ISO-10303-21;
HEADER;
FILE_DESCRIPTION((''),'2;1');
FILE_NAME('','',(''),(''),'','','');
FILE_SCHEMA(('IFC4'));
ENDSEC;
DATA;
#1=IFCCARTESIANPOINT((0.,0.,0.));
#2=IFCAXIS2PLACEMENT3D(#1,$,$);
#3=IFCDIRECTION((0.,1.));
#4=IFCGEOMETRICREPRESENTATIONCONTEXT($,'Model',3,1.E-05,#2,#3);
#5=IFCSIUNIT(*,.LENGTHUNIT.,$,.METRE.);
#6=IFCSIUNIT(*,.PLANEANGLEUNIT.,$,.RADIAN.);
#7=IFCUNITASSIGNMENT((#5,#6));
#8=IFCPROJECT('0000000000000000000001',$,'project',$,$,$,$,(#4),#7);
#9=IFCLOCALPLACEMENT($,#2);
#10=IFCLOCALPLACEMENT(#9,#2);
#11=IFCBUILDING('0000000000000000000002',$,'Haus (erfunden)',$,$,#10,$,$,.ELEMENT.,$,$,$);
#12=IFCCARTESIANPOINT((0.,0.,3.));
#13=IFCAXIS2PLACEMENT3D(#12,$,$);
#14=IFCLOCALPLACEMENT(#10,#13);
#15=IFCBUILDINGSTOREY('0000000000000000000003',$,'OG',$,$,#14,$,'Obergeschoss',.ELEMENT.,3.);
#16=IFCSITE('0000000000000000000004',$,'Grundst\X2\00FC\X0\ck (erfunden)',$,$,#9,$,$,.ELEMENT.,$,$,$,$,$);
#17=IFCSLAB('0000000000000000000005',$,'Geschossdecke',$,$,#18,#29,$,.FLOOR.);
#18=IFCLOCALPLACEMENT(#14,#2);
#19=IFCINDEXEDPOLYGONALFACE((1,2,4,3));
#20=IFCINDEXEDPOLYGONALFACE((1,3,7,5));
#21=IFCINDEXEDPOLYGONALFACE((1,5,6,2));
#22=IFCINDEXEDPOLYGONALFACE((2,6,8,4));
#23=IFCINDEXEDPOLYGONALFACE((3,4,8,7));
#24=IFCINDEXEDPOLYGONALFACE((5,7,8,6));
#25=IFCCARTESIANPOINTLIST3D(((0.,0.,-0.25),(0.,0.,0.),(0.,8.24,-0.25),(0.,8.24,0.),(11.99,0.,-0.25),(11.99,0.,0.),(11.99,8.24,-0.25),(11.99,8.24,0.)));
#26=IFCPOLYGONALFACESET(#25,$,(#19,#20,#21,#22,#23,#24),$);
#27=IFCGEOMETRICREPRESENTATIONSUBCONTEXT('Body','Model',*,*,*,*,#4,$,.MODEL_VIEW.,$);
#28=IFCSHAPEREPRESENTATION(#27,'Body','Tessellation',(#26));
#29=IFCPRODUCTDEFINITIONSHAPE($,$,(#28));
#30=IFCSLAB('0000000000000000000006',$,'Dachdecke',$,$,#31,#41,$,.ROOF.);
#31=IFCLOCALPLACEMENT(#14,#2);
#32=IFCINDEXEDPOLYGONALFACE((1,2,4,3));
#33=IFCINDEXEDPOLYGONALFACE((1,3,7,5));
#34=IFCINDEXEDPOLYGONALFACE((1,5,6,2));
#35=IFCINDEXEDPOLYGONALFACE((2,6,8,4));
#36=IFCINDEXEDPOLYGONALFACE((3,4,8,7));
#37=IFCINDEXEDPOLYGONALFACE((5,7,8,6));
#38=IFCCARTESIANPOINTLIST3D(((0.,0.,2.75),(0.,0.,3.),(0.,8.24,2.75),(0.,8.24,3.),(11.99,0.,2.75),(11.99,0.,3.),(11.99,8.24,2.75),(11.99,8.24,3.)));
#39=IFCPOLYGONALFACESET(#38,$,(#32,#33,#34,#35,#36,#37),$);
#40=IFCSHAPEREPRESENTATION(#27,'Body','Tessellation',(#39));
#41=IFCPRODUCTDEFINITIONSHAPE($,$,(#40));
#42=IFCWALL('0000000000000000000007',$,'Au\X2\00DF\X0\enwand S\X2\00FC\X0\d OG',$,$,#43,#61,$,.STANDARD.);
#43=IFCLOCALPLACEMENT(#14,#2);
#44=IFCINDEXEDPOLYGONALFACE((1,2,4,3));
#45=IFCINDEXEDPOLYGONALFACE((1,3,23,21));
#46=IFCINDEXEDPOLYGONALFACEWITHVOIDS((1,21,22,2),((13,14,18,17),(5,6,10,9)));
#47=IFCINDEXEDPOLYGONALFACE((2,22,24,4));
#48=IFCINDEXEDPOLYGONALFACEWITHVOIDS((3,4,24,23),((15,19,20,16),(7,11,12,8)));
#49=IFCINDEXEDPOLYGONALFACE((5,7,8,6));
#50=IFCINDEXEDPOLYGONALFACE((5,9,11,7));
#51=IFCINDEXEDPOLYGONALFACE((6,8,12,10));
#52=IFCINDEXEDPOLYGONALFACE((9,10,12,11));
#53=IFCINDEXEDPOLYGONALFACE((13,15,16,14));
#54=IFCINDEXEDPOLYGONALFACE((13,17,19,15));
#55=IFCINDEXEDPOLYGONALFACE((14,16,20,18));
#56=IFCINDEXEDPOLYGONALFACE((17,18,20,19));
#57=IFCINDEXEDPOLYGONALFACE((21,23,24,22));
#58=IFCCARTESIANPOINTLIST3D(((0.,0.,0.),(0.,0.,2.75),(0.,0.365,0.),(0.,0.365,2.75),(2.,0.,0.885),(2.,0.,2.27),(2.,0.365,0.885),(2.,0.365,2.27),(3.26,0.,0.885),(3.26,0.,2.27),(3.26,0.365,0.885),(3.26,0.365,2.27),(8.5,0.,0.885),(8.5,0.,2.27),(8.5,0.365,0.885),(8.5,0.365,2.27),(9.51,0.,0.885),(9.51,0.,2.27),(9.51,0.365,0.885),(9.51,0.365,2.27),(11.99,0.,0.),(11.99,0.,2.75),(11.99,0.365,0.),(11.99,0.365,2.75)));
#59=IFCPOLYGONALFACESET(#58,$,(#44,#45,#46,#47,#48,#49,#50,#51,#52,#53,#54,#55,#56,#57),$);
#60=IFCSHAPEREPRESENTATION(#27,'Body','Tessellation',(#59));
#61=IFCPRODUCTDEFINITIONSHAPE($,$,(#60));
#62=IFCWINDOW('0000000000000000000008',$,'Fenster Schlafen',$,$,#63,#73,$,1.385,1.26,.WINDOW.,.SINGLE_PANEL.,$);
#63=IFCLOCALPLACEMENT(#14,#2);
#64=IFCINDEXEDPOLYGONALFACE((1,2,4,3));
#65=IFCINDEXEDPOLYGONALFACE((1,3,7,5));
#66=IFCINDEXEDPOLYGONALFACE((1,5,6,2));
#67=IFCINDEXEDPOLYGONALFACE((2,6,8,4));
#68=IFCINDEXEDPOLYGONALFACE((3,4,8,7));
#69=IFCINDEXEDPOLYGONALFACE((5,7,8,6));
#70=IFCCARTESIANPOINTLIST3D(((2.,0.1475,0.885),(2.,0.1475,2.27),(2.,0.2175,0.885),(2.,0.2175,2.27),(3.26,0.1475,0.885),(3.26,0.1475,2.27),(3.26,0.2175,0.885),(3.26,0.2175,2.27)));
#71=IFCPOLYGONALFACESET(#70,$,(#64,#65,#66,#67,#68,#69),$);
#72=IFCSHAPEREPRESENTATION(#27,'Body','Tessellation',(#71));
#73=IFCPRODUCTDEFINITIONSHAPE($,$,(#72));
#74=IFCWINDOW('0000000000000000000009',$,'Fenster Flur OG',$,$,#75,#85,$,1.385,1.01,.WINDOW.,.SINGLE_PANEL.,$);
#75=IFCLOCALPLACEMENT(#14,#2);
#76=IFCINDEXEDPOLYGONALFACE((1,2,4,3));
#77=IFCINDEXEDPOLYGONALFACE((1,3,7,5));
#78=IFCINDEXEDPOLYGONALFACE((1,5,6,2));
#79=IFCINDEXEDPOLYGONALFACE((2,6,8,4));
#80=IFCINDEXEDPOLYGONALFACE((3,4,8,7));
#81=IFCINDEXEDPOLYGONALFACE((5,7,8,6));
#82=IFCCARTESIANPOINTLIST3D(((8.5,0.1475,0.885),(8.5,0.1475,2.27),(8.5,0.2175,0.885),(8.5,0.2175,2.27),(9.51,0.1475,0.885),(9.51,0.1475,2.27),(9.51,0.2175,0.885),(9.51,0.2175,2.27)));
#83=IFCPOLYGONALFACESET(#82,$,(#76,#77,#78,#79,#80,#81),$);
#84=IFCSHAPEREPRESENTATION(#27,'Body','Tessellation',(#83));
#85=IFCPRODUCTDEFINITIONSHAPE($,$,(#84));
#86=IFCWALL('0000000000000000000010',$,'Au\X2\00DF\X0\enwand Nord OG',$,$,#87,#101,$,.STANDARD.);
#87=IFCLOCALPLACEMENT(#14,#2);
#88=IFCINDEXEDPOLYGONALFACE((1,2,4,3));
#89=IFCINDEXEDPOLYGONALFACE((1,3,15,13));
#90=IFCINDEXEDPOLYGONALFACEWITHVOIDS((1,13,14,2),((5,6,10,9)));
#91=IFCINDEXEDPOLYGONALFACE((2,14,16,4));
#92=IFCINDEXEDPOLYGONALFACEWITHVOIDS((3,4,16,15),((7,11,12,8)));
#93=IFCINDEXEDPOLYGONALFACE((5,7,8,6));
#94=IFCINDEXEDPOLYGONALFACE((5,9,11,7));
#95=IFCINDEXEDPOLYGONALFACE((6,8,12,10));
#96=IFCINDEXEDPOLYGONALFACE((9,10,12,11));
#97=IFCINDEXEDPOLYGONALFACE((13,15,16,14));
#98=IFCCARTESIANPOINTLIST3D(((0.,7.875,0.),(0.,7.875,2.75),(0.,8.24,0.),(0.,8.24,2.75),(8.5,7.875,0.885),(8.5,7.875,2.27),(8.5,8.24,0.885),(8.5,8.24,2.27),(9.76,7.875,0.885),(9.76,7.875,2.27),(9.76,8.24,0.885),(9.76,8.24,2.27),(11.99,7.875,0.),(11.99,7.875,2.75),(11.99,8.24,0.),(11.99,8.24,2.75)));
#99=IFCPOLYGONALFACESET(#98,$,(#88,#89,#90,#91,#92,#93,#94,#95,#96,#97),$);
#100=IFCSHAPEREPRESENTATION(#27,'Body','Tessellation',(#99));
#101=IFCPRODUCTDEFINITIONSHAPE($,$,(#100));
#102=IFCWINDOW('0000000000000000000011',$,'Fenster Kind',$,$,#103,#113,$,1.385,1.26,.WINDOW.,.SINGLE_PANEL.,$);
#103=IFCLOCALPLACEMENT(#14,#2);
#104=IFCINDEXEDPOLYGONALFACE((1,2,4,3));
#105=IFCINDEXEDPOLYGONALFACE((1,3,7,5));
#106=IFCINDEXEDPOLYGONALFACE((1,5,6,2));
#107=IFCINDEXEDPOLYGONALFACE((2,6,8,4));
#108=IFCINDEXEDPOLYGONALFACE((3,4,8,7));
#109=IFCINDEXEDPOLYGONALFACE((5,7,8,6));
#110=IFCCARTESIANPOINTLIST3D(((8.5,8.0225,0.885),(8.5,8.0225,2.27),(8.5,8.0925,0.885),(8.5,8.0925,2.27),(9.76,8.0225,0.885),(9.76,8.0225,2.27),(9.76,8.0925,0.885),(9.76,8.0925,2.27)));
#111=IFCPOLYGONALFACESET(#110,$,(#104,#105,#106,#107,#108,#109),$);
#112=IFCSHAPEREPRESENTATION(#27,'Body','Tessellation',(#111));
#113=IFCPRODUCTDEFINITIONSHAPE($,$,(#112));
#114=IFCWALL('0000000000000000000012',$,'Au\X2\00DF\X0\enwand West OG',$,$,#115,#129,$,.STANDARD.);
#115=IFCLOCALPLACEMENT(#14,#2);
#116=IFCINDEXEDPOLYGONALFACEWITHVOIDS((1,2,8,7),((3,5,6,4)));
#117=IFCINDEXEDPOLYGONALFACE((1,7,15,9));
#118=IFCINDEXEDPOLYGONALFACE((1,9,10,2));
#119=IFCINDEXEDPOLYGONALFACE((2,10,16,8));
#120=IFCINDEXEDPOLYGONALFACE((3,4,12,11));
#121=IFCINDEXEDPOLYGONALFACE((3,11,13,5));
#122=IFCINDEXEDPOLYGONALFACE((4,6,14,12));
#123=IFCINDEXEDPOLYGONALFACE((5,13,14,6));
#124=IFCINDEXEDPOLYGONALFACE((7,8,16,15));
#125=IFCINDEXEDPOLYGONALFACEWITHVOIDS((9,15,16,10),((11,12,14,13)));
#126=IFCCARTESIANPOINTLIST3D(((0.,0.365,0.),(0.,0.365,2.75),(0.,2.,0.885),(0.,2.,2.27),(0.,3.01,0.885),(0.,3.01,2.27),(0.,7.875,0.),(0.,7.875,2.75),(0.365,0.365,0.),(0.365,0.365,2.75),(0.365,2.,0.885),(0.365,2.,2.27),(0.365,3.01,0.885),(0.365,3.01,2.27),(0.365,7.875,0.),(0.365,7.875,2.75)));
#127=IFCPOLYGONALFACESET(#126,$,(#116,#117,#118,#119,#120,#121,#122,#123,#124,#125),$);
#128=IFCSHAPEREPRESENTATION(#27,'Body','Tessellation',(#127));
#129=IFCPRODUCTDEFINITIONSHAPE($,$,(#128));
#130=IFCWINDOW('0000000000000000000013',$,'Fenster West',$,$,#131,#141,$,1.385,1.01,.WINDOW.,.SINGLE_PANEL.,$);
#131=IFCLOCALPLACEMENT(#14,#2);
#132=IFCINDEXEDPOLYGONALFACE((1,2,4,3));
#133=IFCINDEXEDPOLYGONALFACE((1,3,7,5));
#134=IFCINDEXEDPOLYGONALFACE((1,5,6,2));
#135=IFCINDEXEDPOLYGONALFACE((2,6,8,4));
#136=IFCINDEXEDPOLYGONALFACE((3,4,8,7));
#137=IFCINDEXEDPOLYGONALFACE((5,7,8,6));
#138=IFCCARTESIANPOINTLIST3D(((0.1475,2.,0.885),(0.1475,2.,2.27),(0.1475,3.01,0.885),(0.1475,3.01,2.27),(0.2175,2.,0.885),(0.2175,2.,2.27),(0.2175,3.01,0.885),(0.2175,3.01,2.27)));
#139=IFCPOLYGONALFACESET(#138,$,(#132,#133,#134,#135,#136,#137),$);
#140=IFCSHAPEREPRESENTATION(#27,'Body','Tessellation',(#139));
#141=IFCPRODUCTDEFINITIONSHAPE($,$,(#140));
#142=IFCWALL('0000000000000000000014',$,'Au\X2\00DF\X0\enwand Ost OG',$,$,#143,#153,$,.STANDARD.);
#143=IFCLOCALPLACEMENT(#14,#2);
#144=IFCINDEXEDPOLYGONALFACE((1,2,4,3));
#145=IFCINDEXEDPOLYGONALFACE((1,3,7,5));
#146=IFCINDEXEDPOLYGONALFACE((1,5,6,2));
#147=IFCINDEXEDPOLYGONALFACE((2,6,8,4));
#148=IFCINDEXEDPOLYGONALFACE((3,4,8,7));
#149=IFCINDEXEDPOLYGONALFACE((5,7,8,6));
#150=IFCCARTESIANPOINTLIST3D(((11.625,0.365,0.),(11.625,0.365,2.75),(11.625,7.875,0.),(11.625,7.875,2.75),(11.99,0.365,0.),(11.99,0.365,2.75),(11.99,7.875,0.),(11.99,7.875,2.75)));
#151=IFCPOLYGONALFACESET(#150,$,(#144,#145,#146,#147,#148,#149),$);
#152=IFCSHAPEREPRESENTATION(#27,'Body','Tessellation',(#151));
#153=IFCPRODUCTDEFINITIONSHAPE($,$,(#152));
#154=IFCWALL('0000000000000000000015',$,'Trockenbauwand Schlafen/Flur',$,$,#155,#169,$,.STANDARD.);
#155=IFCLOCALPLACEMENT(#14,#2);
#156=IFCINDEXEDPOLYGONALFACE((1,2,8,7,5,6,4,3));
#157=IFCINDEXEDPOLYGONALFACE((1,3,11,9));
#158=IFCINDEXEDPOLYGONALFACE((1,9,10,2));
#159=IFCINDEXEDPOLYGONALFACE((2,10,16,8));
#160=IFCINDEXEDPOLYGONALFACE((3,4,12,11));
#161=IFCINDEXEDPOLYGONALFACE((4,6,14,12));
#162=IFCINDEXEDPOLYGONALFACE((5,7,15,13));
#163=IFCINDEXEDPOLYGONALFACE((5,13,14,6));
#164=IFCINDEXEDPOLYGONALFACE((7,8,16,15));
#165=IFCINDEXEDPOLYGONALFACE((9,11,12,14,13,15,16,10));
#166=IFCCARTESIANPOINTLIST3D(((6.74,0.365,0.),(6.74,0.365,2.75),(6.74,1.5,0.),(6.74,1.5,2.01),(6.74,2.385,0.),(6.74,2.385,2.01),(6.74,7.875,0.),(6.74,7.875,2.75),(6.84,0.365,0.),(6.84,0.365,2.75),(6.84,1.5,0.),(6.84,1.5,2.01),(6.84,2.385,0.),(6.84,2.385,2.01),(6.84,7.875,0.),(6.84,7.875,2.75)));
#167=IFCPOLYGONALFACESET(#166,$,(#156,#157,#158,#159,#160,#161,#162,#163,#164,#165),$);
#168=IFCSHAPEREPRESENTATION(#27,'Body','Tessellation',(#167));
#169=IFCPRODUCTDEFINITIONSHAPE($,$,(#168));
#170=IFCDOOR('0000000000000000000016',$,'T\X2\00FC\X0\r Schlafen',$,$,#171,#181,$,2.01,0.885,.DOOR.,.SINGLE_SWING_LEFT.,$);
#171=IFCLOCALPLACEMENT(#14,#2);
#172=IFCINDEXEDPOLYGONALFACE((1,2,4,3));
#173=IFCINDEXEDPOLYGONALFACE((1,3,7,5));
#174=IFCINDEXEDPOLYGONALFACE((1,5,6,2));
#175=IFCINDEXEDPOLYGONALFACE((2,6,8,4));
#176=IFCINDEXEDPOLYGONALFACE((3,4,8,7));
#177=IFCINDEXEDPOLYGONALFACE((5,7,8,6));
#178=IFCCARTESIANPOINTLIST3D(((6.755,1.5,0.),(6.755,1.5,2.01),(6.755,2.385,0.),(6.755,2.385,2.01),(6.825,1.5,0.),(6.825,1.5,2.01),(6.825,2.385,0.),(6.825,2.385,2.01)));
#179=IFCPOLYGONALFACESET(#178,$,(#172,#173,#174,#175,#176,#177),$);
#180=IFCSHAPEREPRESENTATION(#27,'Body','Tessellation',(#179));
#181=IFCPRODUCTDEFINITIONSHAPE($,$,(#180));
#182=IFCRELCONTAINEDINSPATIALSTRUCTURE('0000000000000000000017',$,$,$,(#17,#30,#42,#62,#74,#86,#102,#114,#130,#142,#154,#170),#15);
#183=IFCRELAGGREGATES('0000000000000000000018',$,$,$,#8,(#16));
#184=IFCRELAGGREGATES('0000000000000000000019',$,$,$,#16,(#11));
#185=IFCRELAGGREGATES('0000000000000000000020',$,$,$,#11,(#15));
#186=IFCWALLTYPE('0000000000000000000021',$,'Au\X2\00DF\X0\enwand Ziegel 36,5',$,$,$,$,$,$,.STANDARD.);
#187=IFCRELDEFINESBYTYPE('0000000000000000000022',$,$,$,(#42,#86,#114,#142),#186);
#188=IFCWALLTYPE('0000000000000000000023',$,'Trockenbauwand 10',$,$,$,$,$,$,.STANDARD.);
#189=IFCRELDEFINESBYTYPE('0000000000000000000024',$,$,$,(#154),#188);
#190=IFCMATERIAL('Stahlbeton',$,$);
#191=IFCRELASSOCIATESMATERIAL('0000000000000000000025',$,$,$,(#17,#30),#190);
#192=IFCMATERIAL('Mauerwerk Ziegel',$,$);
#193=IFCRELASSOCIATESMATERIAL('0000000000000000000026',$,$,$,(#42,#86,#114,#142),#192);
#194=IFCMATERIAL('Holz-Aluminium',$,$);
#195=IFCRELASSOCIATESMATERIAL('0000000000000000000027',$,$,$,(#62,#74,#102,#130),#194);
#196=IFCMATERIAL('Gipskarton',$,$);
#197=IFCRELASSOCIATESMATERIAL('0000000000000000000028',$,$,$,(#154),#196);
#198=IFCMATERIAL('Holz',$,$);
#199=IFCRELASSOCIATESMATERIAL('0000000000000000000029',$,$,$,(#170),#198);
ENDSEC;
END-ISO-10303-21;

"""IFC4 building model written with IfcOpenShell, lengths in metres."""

from ifc_helpers import new_model, si_unit, direction, frame, frame_2d, origin, place, context, subcontext, project, spatial, rectangle, extrude, material, type_object, element, fill, save


model = new_model("IFC4")

# Units and contexts
model_context = context("Model", 3, precision=1e-05, world=origin(), true_north=direction((0.0, 1.0)))
body_context = subcontext(model_context, "Body", "Model", "MODEL_VIEW")
ifc_project = project(units=[si_unit("LENGTHUNIT", "METRE"), si_unit("PLANEANGLEUNIT", "RADIAN")], contexts=[model_context])

# Site, building, storey
site_placement = place(None, origin())
site = spatial("IfcSite", under=ifc_project, at=site_placement, Name="Grundstück (erfunden)", CompositionType="ELEMENT")
building_placement = place(site_placement, origin())
building = spatial("IfcBuilding", under=site, at=building_placement, Name="Haus (erfunden)", CompositionType="ELEMENT")
storey_placement = place(building_placement, frame((0.0, 0.0, 3.0)))
storey = spatial("IfcBuildingStorey", under=building, at=storey_placement, Name="OG", LongName="Obergeschoss", CompositionType="ELEMENT", Elevation=3.0)

# Slabs
ifc_material_1 = material(Name="Stahlbeton")
slab_1_placement = place(storey_placement, frame((0.0, 0.0, -0.25)))
element("IfcSlab", 1, at=slab_1_placement, inside=storey, material=ifc_material_1, Name="Geschossdecke", PredefinedType="FLOOR", context=body_context, shape_type="SweptSolid", body=[
    extrude(rectangle(XDim=11.99, YDim=8.24, at=frame_2d((5.995, 4.12))), origin(), (0.0, 0.0, 1.0), 0.25),
])
slab_2_placement = place(storey_placement, frame((0.0, 0.0, 2.75)))
element("IfcSlab", 2, at=slab_2_placement, inside=storey, material=ifc_material_1, Name="Dachdecke", PredefinedType="ROOF", context=body_context, shape_type="SweptSolid", body=[
    extrude(rectangle(XDim=11.99, YDim=8.24, at=frame_2d((5.995, 4.12))), origin(), (0.0, 0.0, 1.0), 0.25),
])

# Wall, openings, windows
ifc_material_2 = material(Name="Mauerwerk Ziegel")
wall_type_1 = type_object("IfcWallType", Name="Außenwand Ziegel 36,5", PredefinedType="STANDARD")
wall_1_placement = place(storey_placement, origin())
wall_1 = element("IfcWall", 3, at=wall_1_placement, inside=storey, type_object=wall_type_1, material=ifc_material_2, Name="Außenwand Süd OG", PredefinedType="STANDARD", context=body_context, shape_type="SweptSolid", body=[
    extrude(rectangle(XDim=11.99, YDim=0.365, at=frame_2d((5.995, 0.1825))), origin(), (0.0, 0.0, 1.0), 2.75),
])
opening_1_placement = place(wall_1_placement, frame((2.0, -0.05, 0.885)))
opening_1 = element("IfcOpeningElement", 4, at=opening_1_placement, cuts=wall_1, PredefinedType="OPENING", context=body_context, shape_type="SweptSolid", body=[
    extrude(rectangle(XDim=1.26, YDim=0.465, at=frame_2d((0.63, 0.2325))), origin(), (0.0, 0.0, 1.0), 1.385),
])
opening_2_placement = place(wall_1_placement, frame((8.5, -0.05, 0.885)))
opening_2 = element("IfcOpeningElement", 5, at=opening_2_placement, cuts=wall_1, PredefinedType="OPENING", context=body_context, shape_type="SweptSolid", body=[
    extrude(rectangle(XDim=1.01, YDim=0.465, at=frame_2d((0.505, 0.2325))), origin(), (0.0, 0.0, 1.0), 1.385),
])
ifc_material_3 = material(Name="Holz-Aluminium")
window_1_placement = place(opening_1_placement, frame((0.0, 0.1975, 0.0)))
window_1 = element("IfcWindow", 6, at=window_1_placement, inside=storey, material=ifc_material_3, Name="Fenster Schlafen", OverallHeight=1.385, OverallWidth=1.26, PartitioningType="SINGLE_PANEL", PredefinedType="WINDOW", context=body_context, shape_type="SweptSolid", body=[
    extrude(rectangle(XDim=1.26, YDim=0.07, at=frame_2d((0.63, 0.035))), origin(), (0.0, 0.0, 1.0), 1.385),
])
fill(opening_1, window_1)
window_2_placement = place(opening_2_placement, frame((0.0, 0.1975, 0.0)))
window_2 = element("IfcWindow", 7, at=window_2_placement, inside=storey, material=ifc_material_3, Name="Fenster Flur OG", OverallHeight=1.385, OverallWidth=1.01, PartitioningType="SINGLE_PANEL", PredefinedType="WINDOW", context=body_context, shape_type="SweptSolid", body=[
    extrude(rectangle(XDim=1.01, YDim=0.07, at=frame_2d((0.505, 0.035))), origin(), (0.0, 0.0, 1.0), 1.385),
])
fill(opening_2, window_2)

# Walls, openings, windows
wall_2_placement = place(storey_placement, frame((0.0, 7.875, 0.0)))
wall_2 = element("IfcWall", 8, at=wall_2_placement, inside=storey, type_object=wall_type_1, material=ifc_material_2, Name="Außenwand Nord OG", PredefinedType="STANDARD", context=body_context, shape_type="SweptSolid", body=[
    extrude(rectangle(XDim=11.99, YDim=0.365, at=frame_2d((5.995, 0.1825))), origin(), (0.0, 0.0, 1.0), 2.75),
])
opening_3_placement = place(wall_2_placement, frame((8.5, -0.05, 0.885)))
opening_3 = element("IfcOpeningElement", 9, at=opening_3_placement, cuts=wall_2, PredefinedType="OPENING", context=body_context, shape_type="SweptSolid", body=[
    extrude(rectangle(XDim=1.26, YDim=0.465, at=frame_2d((0.63, 0.2325))), origin(), (0.0, 0.0, 1.0), 1.385),
])
window_3_placement = place(opening_3_placement, frame((0.0, 0.1975, 0.0)))
window_3 = element("IfcWindow", 10, at=window_3_placement, inside=storey, material=ifc_material_3, Name="Fenster Kind", OverallHeight=1.385, OverallWidth=1.26, PartitioningType="SINGLE_PANEL", PredefinedType="WINDOW", context=body_context, shape_type="SweptSolid", body=[
    extrude(rectangle(XDim=1.26, YDim=0.07, at=frame_2d((0.63, 0.035))), origin(), (0.0, 0.0, 1.0), 1.385),
])
fill(opening_3, window_3)
wall_3_placement = place(storey_placement, frame((0.0, 0.365, 0.0)))
wall_3 = element("IfcWall", 11, at=wall_3_placement, inside=storey, type_object=wall_type_1, material=ifc_material_2, Name="Außenwand West OG", PredefinedType="STANDARD", context=body_context, shape_type="SweptSolid", body=[
    extrude(rectangle(XDim=0.365, YDim=7.51, at=frame_2d((0.1825, 3.755))), origin(), (0.0, 0.0, 1.0), 2.75),
])
opening_4_placement = place(wall_3_placement, frame((-0.05, 1.635, 0.885)))
opening_4 = element("IfcOpeningElement", 12, at=opening_4_placement, cuts=wall_3, PredefinedType="OPENING", context=body_context, shape_type="SweptSolid", body=[
    extrude(rectangle(XDim=0.465, YDim=1.01, at=frame_2d((0.2325, 0.505))), origin(), (0.0, 0.0, 1.0), 1.385),
])
window_4_placement = place(opening_4_placement, frame((0.1975, 0.0, 0.0)))
window_4 = element("IfcWindow", 13, at=window_4_placement, inside=storey, material=ifc_material_3, Name="Fenster West", OverallHeight=1.385, OverallWidth=1.01, PartitioningType="SINGLE_PANEL", PredefinedType="WINDOW", context=body_context, shape_type="SweptSolid", body=[
    extrude(rectangle(XDim=0.07, YDim=1.01, at=frame_2d((0.035, 0.505))), origin(), (0.0, 0.0, 1.0), 1.385),
])
fill(opening_4, window_4)

# Wall
wall_4_placement = place(storey_placement, frame((11.625, 0.365, 0.0)))
element("IfcWall", 14, at=wall_4_placement, inside=storey, type_object=wall_type_1, material=ifc_material_2, Name="Außenwand Ost OG", PredefinedType="STANDARD", context=body_context, shape_type="SweptSolid", body=[
    extrude(rectangle(XDim=0.365, YDim=7.51, at=frame_2d((0.1825, 3.755))), origin(), (0.0, 0.0, 1.0), 2.75),
])

# Wall, opening, door
ifc_material_4 = material(Name="Gipskarton")
wall_type_2 = type_object("IfcWallType", Name="Trockenbauwand 10", PredefinedType="STANDARD")
wall_5_placement = place(storey_placement, frame((6.74, 0.365, 0.0)))
wall_5 = element("IfcWall", 15, at=wall_5_placement, inside=storey, type_object=wall_type_2, material=ifc_material_4, Name="Trockenbauwand Schlafen/Flur", PredefinedType="STANDARD", context=body_context, shape_type="SweptSolid", body=[
    extrude(rectangle(XDim=0.1, YDim=7.51, at=frame_2d((0.05, 3.755))), origin(), (0.0, 0.0, 1.0), 2.75),
])
opening_5_placement = place(wall_5_placement, frame((-0.05, 1.135, 0.0)))
opening_5 = element("IfcOpeningElement", 16, at=opening_5_placement, cuts=wall_5, PredefinedType="OPENING", context=body_context, shape_type="SweptSolid", body=[
    extrude(rectangle(XDim=0.2, YDim=0.885, at=frame_2d((0.1, 0.4425))), origin(), (0.0, 0.0, 1.0), 2.01),
])
ifc_material_5 = material(Name="Holz")
door_1_placement = place(opening_5_placement, frame((0.065, 0.0, 0.0)))
door_1 = element("IfcDoor", 17, at=door_1_placement, inside=storey, material=ifc_material_5, Name="Tür Schlafen", OperationType="SINGLE_SWING_LEFT", OverallHeight=2.01, OverallWidth=0.885, PredefinedType="DOOR", context=body_context, shape_type="SweptSolid", body=[
    extrude(rectangle(XDim=0.07, YDim=0.885, at=frame_2d((0.035, 0.4425))), origin(), (0.0, 0.0, 1.0), 2.01),
])
fill(opening_5, door_1)

save(model, "model.ifc")
